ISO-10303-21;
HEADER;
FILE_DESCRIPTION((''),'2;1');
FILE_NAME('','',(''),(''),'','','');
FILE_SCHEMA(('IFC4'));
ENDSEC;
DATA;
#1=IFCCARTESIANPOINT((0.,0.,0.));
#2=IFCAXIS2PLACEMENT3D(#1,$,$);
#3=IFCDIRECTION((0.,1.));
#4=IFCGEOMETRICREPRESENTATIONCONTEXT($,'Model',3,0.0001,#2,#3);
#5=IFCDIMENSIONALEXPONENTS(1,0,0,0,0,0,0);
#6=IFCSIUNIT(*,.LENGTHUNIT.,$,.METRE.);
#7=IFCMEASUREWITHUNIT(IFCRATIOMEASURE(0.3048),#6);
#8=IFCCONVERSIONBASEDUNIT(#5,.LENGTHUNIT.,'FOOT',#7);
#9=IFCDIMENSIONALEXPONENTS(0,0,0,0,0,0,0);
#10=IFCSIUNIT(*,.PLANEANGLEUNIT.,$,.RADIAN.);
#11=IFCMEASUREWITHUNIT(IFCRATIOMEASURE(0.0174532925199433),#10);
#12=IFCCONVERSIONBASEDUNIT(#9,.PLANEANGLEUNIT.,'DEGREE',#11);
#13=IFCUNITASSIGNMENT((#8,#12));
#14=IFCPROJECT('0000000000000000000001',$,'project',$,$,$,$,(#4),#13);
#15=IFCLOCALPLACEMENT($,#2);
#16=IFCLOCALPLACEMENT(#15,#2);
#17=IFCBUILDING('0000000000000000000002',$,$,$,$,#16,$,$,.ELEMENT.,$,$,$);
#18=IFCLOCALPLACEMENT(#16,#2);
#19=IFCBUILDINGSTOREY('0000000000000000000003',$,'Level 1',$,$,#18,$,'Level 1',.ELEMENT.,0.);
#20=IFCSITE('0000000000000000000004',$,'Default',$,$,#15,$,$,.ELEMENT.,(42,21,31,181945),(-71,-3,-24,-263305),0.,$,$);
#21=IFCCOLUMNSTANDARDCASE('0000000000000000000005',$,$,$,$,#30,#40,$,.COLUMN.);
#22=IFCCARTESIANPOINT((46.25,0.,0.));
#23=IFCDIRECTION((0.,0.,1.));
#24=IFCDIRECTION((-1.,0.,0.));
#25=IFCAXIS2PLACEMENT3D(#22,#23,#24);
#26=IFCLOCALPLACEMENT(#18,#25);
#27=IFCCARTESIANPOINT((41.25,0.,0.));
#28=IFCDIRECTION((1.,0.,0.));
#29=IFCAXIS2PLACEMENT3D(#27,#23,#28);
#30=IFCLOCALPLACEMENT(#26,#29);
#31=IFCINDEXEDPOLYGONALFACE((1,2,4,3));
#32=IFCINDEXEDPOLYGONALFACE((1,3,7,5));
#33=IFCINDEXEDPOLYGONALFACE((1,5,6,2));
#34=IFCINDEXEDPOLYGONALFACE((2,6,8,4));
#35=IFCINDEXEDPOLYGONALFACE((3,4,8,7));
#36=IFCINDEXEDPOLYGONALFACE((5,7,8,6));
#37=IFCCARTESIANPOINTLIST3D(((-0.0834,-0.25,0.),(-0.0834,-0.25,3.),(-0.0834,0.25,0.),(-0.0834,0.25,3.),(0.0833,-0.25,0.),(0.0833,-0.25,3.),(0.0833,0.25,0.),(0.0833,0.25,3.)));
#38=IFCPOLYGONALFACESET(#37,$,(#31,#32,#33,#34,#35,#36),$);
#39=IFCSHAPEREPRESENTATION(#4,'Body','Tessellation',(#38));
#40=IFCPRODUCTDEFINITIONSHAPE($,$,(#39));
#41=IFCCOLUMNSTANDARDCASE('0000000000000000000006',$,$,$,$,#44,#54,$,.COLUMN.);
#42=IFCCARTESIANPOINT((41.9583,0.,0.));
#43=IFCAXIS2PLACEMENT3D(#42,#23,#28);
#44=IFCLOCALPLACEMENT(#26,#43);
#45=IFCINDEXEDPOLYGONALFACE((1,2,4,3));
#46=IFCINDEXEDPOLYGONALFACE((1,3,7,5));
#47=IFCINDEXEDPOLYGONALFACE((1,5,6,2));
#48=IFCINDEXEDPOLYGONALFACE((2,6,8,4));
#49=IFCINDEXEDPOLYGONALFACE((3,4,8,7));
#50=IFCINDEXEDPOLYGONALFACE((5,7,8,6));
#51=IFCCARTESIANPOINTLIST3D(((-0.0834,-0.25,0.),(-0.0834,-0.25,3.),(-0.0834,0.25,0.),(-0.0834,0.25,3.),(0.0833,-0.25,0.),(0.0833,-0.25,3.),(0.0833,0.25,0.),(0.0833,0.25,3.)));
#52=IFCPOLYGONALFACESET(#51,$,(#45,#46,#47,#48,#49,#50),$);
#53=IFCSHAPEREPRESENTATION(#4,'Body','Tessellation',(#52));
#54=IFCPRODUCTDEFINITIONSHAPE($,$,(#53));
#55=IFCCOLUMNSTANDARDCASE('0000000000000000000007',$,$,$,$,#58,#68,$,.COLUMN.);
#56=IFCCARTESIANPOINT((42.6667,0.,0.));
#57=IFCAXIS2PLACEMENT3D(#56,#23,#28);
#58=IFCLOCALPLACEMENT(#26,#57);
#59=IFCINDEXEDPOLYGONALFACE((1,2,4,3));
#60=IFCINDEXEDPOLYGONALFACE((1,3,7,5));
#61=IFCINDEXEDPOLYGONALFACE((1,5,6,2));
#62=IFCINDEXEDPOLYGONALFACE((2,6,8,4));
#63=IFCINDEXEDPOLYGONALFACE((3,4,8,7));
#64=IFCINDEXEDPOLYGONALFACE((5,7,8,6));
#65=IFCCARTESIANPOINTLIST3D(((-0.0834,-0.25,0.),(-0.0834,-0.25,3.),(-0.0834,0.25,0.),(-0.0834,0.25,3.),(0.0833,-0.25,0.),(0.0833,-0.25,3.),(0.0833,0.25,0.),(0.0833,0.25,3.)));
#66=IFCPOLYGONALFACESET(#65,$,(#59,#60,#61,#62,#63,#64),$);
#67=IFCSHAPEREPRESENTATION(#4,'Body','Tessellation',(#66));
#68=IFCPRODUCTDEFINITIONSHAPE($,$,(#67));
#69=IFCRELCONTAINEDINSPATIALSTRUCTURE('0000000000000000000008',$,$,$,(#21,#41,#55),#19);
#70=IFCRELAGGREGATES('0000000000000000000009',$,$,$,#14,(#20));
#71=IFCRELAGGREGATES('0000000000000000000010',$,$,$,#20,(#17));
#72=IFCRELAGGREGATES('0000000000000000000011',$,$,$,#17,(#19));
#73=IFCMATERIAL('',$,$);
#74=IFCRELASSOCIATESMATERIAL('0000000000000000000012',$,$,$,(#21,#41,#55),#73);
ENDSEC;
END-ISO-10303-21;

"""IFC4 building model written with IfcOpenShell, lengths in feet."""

from ifc_helpers import new_model, entity, si_unit, converted_unit, direction, frame, origin, place, context, project, spatial, rectangle, extrude, material, element, save


model = new_model("IFC4")

# Units and contexts
model_context = context("Model", 3, precision=0.0001, world=origin(), true_north=direction((0.0, 1.0)))
ifc_project = project(units=[converted_unit("LENGTHUNIT", "FOOT", entity("IfcRatioMeasure", 0.3048), si_unit("LENGTHUNIT", "METRE"), dimensions=[1, 0, 0, 0, 0, 0, 0]), converted_unit("PLANEANGLEUNIT", "DEGREE", entity("IfcRatioMeasure", 0.0174532925199433), si_unit("PLANEANGLEUNIT", "RADIAN"), dimensions=[0, 0, 0, 0, 0, 0, 0])], contexts=[model_context])

# Site, building, storey
site_placement = place(None, origin())
site = spatial("IfcSite", under=ifc_project, at=site_placement, Name="Default", CompositionType="ELEMENT", RefLatitude=(42, 21, 31, 181945), RefLongitude=(-71, -3, -24, -263305), RefElevation=0.0)
building_placement = place(site_placement, origin())
building = spatial("IfcBuilding", under=site, at=building_placement, CompositionType="ELEMENT")
storey_placement = place(building_placement, origin())
storey = spatial("IfcBuildingStorey", under=building, at=storey_placement, Name="Level 1", LongName="Level 1", CompositionType="ELEMENT", Elevation=0.0)

# Columns
placement = place(storey_placement, frame((46.25, 0.0, 0.0), z_axis=(0.0, 0.0, 1.0), x_axis=(-1.0, 0.0, 0.0)))
ifc_material_1 = material(Name="")
for number, where, z_axis, x_axis in (
    (1, (41.25, 0.0, 0.0), (0.0, 0.0, 1.0), (1.0, 0.0, 0.0)),
    (2, (41.9583, 0.0, 0.0), (0.0, 0.0, 1.0), (1.0, 0.0, 0.0)),
    (3, (42.6667, 0.0, 0.0), (0.0, 0.0, 1.0), (1.0, 0.0, 0.0)),
):
    element("IfcColumnStandardCase", number, at=place(placement, frame(where, z_axis=z_axis, x_axis=x_axis)), inside=storey, material=ifc_material_1, PredefinedType="COLUMN", context=model_context, shape_type="SweptSolid", body=[
        extrude(rectangle(XDim=0.1667, YDim=0.5), origin(), (0.0, 0.0, 1.0), 3.0),
    ])

save(model, "model.ifc")
